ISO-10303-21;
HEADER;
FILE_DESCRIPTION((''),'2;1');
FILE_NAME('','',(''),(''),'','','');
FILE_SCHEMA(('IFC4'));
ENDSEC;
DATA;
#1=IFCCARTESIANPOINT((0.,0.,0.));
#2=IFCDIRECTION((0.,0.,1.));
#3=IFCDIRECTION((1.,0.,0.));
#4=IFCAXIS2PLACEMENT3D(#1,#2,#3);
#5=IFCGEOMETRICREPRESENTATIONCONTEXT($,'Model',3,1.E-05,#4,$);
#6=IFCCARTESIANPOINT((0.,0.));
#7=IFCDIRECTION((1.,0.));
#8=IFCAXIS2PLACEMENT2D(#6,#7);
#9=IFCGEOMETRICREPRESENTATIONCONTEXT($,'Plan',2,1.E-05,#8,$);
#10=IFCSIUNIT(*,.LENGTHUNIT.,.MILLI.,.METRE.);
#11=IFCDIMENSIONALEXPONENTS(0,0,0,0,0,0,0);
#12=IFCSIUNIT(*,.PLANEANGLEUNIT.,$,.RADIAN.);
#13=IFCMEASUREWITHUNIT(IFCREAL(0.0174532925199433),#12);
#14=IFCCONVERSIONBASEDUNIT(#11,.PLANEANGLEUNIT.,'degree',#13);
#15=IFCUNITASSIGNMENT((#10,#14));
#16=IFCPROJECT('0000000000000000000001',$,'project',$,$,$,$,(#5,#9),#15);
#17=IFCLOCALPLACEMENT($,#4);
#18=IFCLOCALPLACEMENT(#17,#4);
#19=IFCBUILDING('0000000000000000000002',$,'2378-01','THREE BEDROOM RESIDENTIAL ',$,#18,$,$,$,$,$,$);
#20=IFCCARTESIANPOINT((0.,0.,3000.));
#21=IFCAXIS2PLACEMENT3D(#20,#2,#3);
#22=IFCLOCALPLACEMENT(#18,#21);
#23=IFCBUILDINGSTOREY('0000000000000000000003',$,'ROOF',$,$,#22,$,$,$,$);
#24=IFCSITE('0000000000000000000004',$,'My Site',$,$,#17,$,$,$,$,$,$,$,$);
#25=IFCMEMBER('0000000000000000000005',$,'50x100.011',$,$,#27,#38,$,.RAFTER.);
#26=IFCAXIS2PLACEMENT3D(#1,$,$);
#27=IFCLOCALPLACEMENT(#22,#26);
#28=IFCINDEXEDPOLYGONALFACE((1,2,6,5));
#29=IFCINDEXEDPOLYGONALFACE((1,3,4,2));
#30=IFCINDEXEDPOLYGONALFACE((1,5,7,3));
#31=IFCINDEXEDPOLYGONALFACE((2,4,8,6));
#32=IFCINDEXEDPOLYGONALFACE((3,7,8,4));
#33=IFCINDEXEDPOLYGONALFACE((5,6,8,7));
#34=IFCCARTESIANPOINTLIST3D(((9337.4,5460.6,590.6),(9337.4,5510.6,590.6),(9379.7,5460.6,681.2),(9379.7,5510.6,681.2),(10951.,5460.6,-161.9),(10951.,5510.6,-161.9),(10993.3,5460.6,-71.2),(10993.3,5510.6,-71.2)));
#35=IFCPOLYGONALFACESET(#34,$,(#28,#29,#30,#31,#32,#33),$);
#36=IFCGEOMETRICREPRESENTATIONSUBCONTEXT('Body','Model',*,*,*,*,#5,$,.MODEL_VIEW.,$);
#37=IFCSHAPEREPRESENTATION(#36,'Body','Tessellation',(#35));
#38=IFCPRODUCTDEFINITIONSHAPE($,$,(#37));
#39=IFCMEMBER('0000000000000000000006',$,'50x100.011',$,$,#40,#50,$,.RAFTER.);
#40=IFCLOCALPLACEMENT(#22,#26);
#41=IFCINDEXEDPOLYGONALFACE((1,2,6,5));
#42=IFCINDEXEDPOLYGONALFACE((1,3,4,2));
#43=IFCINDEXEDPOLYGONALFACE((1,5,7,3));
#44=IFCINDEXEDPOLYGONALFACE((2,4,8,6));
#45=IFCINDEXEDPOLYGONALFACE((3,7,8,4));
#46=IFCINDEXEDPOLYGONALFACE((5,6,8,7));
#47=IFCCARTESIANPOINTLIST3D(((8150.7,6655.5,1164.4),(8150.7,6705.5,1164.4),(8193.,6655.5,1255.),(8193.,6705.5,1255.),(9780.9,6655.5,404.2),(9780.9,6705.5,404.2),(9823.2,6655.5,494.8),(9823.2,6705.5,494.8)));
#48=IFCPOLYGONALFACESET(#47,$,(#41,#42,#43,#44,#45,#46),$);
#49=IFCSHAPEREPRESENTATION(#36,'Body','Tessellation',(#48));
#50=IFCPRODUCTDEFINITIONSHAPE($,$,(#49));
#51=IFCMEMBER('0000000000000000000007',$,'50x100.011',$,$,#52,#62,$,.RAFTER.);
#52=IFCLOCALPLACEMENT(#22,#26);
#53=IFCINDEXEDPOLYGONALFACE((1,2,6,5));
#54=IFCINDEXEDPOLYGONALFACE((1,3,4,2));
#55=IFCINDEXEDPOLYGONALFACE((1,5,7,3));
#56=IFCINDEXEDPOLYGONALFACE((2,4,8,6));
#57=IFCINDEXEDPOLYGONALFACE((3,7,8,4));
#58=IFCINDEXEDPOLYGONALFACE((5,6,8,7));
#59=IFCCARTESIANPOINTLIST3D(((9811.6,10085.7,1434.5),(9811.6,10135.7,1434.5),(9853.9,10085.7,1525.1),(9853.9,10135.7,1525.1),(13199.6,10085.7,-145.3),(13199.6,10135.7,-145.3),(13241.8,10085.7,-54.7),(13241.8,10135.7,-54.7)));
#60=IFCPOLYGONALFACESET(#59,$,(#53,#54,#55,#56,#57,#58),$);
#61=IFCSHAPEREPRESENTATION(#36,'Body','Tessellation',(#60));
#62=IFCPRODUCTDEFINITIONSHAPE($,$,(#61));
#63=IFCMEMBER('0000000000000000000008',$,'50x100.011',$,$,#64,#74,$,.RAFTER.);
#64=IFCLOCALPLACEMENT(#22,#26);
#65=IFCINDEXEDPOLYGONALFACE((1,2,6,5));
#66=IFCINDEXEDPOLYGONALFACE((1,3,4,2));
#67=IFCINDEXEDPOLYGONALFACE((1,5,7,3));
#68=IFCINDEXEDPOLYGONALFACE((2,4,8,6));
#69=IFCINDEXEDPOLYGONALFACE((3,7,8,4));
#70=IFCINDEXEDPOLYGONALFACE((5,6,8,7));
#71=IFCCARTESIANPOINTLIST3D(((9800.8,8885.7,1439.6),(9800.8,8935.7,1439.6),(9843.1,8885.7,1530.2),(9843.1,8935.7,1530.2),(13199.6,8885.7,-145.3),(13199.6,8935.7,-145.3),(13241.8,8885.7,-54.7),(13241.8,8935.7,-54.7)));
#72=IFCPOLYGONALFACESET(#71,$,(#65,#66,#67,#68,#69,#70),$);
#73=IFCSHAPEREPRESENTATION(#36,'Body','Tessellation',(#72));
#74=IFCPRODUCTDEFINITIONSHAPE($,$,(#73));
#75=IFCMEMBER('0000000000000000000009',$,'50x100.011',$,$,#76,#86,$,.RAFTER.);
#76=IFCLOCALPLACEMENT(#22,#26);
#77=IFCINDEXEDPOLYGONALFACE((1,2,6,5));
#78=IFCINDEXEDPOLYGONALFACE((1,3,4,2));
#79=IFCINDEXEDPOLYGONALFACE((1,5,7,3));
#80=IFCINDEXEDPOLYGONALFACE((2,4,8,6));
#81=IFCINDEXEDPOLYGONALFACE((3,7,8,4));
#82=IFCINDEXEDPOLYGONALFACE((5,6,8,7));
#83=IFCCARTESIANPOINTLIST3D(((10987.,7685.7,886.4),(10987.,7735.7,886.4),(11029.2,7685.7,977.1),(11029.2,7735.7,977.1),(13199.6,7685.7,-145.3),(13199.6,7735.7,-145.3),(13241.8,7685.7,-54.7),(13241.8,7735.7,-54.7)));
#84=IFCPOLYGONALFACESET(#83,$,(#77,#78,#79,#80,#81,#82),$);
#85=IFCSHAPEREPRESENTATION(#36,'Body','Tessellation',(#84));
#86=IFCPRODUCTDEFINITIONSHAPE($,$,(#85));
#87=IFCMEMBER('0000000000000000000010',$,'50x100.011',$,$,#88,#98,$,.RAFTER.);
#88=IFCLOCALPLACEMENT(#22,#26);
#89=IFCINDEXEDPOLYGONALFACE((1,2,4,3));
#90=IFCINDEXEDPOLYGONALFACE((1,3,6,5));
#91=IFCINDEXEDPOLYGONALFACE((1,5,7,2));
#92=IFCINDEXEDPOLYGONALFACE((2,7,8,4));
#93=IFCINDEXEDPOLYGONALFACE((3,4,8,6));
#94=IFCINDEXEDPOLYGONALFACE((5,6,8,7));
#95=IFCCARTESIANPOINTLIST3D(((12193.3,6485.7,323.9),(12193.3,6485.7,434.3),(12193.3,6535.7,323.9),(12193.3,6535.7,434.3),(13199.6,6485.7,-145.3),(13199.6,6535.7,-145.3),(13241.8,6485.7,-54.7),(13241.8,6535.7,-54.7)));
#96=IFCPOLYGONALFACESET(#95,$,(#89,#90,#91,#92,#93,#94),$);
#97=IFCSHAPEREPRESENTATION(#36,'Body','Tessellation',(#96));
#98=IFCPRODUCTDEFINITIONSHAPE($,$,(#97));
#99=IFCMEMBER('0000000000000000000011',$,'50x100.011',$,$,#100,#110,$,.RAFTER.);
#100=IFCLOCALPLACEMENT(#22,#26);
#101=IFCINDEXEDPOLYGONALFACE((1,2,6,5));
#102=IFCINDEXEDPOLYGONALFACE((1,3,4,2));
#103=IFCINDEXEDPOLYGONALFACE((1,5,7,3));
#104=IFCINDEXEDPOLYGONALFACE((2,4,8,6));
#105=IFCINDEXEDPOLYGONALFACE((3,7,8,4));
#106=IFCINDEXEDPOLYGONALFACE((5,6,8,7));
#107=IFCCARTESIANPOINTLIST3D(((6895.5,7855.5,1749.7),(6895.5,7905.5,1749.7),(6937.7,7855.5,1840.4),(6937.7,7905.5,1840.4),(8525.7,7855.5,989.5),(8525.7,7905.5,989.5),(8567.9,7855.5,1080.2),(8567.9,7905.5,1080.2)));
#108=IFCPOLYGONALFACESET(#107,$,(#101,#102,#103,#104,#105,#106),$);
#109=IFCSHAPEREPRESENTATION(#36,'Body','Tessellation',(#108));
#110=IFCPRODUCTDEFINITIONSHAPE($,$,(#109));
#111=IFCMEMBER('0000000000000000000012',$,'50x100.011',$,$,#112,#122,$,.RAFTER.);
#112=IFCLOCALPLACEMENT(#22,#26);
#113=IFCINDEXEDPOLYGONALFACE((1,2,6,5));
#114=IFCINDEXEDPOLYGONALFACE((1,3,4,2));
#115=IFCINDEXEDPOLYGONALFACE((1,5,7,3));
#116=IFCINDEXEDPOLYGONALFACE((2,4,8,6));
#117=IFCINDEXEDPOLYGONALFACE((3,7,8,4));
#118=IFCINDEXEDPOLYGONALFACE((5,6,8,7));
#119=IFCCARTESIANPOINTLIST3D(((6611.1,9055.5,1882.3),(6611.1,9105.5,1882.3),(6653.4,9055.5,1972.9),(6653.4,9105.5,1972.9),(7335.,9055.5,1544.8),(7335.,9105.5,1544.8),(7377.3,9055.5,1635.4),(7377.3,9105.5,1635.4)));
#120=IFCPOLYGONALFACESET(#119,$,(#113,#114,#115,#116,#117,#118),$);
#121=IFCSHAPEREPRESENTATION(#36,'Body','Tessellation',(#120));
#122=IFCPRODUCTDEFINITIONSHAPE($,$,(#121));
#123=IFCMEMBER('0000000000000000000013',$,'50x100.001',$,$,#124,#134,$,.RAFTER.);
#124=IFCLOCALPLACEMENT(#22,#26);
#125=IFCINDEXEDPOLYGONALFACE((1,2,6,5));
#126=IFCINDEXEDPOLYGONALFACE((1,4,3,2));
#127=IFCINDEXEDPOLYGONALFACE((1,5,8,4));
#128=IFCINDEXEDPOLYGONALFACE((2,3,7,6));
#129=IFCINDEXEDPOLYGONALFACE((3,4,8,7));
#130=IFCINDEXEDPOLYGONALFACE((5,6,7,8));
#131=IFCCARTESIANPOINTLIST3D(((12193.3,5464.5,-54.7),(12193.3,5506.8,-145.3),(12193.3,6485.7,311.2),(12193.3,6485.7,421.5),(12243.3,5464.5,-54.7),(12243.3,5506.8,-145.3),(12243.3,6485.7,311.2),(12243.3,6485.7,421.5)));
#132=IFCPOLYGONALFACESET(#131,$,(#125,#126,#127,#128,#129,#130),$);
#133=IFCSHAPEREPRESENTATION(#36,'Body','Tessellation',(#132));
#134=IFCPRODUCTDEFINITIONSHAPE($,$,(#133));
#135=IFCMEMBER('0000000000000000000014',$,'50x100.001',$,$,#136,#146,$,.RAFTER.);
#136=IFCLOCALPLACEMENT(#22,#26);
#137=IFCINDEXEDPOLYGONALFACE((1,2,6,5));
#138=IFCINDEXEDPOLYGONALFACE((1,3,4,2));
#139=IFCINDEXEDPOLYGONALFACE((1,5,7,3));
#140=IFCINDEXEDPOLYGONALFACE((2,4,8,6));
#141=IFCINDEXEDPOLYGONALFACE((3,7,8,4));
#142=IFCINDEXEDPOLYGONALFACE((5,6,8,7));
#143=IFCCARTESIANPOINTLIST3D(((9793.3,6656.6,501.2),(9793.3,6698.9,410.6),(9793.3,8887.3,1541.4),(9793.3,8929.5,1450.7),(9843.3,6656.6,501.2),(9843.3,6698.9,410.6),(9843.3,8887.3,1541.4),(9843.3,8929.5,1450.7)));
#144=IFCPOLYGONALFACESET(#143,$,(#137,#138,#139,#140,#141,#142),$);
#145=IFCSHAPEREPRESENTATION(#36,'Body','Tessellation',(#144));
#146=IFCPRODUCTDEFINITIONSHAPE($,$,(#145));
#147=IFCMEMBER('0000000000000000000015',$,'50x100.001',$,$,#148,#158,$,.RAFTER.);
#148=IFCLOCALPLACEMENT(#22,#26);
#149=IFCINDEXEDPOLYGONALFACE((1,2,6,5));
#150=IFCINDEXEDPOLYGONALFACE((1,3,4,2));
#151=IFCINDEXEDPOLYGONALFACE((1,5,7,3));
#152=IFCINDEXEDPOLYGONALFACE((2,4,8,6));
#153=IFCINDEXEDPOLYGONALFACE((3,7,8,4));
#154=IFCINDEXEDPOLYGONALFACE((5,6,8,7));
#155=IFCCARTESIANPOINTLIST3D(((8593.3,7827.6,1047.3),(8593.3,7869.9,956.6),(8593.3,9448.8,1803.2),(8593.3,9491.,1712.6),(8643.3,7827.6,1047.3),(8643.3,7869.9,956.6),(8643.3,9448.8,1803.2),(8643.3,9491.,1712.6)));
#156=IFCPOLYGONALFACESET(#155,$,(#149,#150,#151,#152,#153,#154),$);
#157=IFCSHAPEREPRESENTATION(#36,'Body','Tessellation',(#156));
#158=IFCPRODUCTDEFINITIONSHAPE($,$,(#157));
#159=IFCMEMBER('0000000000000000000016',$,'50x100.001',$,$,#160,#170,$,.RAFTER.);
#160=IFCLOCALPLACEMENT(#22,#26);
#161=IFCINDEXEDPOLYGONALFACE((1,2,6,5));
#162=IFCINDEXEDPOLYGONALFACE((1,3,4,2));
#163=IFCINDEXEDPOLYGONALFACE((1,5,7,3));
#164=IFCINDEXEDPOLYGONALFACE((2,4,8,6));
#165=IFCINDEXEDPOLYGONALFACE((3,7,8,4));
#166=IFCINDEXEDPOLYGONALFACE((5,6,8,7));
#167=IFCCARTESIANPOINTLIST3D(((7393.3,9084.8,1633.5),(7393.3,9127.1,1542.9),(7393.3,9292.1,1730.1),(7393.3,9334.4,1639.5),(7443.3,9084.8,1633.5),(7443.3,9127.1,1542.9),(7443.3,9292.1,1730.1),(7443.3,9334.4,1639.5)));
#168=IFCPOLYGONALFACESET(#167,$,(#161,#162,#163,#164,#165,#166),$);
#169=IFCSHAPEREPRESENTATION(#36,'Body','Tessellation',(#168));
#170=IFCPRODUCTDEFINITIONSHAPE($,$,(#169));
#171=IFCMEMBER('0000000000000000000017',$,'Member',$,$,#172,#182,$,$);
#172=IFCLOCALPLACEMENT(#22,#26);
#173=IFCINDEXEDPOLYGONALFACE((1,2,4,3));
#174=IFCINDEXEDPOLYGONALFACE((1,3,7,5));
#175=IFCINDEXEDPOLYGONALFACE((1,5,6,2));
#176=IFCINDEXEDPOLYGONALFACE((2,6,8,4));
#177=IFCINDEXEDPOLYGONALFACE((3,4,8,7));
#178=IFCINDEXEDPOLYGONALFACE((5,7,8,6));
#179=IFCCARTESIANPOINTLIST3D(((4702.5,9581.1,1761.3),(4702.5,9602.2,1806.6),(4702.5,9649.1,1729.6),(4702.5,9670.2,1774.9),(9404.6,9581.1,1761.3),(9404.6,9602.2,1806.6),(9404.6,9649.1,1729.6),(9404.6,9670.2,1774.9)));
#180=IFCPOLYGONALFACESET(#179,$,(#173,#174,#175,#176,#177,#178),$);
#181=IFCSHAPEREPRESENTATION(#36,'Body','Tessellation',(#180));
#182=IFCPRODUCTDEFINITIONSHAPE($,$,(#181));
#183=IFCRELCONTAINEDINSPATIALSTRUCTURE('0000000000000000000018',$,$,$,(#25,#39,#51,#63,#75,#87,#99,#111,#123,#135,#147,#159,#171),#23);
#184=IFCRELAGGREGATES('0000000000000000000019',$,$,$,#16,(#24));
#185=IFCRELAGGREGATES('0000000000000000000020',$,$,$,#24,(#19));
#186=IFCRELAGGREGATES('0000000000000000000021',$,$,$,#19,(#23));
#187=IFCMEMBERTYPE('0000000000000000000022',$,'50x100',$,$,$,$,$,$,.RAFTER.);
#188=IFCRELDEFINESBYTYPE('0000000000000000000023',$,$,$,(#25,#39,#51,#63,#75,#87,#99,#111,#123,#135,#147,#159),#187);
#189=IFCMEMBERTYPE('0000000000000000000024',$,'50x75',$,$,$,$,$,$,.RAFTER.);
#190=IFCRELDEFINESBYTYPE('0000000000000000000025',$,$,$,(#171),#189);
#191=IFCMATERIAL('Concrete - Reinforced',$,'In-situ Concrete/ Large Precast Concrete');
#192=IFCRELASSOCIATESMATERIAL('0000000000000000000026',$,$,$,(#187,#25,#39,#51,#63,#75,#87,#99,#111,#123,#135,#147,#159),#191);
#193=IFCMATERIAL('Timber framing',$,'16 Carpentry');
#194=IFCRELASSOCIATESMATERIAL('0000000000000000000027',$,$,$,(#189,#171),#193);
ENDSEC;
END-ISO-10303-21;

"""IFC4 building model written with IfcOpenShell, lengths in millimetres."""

from ifc_helpers import new_model, entity, si_unit, converted_unit, frame, origin_with_axes, origin_2d_with_axis, place, context, subcontext, project, spatial, rectangle, extrude, clip, halfspace, material, material_profile, profile_set, profile_usage, type_object, element, save


model = new_model("IFC4")

# Units and contexts
model_context = context("Model", 3, precision=1e-05, world=origin_with_axes())
plan_context = context("Plan", 2, precision=1e-05, world=origin_2d_with_axis())
body_context = subcontext(model_context, "Body", "Model", "MODEL_VIEW")
ifc_project = project(units=[si_unit("LENGTHUNIT", "METRE", prefix="MILLI"), converted_unit("PLANEANGLEUNIT", "degree", entity("IfcReal", 0.0174532925199433), si_unit("PLANEANGLEUNIT", "RADIAN"), dimensions=[0, 0, 0, 0, 0, 0, 0])], contexts=[model_context, plan_context])

# Site, building, storey
site_placement = place(None, origin_with_axes())
site = spatial("IfcSite", under=ifc_project, at=site_placement, Name="My Site")
building_placement = place(site_placement, origin_with_axes())
building = spatial("IfcBuilding", under=site, at=building_placement, Name="2378-01", Description="THREE BEDROOM RESIDENTIAL ")
storey_placement = place(building_placement, frame((0.0, 0.0, 3000.0), z_axis=(0.0, 0.0, 1.0), x_axis=(1.0, 0.0, 0.0)))
storey = spatial("IfcBuildingStorey", under=building, at=storey_placement, Name="ROOF")

# Members
ifc_material_1 = material(Name="Concrete - Reinforced", Category="In-situ Concrete/ Large Precast Concrete")
ifc_material_profile_1 = material_profile(ifc_material_1, rectangle(XDim=50.0, YDim=100.0), Name="Core Layer", Category="LoadBearing", Priority=1)
ifc_profile_set_1 = profile_set([ifc_material_profile_1], Name="wood")
ifc_profile_usage_1 = profile_usage(ifc_profile_set_1, cardinal=5)
member_type_1 = type_object("IfcMemberType", Name="50x100", PredefinedType="RAFTER", material=ifc_profile_set_1)
member_1_placement = place(storey_placement, frame((10972.1, 5485.6, -116.6), z_axis=(-0.906308, 0.0, 0.422618), x_axis=(0.0, -1.0, 0.0)))
element("IfcMember", 1, at=member_1_placement, inside=storey, type_object=member_type_1, material=ifc_profile_usage_1, Name="50x100.011", PredefinedType="RAFTER", context=body_context, shape_type="SweptSolid", body=[
    extrude(rectangle(XDim=50.0, YDim=100.0), origin_with_axes(), (0.0, 0.0, 1.0), 1780.4),
])
ifc_profile_usage_2 = profile_usage(ifc_profile_set_1, cardinal=5)
member_2_placement = place(storey_placement, frame((9802.1, 6680.5, 449.5), z_axis=(-0.906308, 0.0, 0.422618), x_axis=(0.0, -1.0, 0.0)))
element("IfcMember", 2, at=member_2_placement, inside=storey, type_object=member_type_1, material=ifc_profile_usage_2, Name="50x100.011", PredefinedType="RAFTER", context=body_context, shape_type="SweptSolid", body=[
    extrude(rectangle(XDim=50.0, YDim=100.0), origin_with_axes(), (0.0, 0.0, 1.0), 1798.8),
])
ifc_profile_usage_3 = profile_usage(ifc_profile_set_1, cardinal=5)
member_3_placement = place(storey_placement, frame((13220.7, 10110.7, -100.0), z_axis=(-0.906308, 0.0, 0.422618), x_axis=(0.0, -1.0, 0.0)))
element("IfcMember", 3, at=member_3_placement, inside=storey, type_object=member_type_1, material=ifc_profile_usage_3, Name="50x100.011", PredefinedType="RAFTER", context=body_context, shape_type="SweptSolid", body=[
    extrude(rectangle(XDim=50.0, YDim=100.0), origin_with_axes(), (0.0, 0.0, 1.0), 3738.2),
])
ifc_profile_usage_4 = profile_usage(ifc_profile_set_1, cardinal=5)
member_4_placement = place(storey_placement, frame((13220.7, 8910.7, -100.0), z_axis=(-0.906308, 0.0, 0.422618), x_axis=(0.0, -1.0, 0.0)))
element("IfcMember", 4, at=member_4_placement, inside=storey, type_object=member_type_1, material=ifc_profile_usage_4, Name="50x100.011", PredefinedType="RAFTER", context=body_context, shape_type="SweptSolid", body=[
    extrude(rectangle(XDim=50.0, YDim=100.0), origin_with_axes(), (0.0, 0.0, 1.0), 3750.1),
])
ifc_profile_usage_5 = profile_usage(ifc_profile_set_1, cardinal=5)
member_5_placement = place(storey_placement, frame((13220.7, 7710.7, -100.0), z_axis=(-0.906308, 0.0, 0.422618), x_axis=(0.0, -1.0, 0.0)))
element("IfcMember", 5, at=member_5_placement, inside=storey, type_object=member_type_1, material=ifc_profile_usage_5, Name="50x100.011", PredefinedType="RAFTER", context=body_context, shape_type="SweptSolid", body=[
    extrude(rectangle(XDim=50.0, YDim=100.0), origin_with_axes(), (0.0, 0.0, 1.0), 2441.3),
])
ifc_profile_usage_6 = profile_usage(ifc_profile_set_1, cardinal=5)
member_6_placement = place(storey_placement, frame((13220.7, 6510.7, -100.0), z_axis=(-0.906308, 0.0, 0.422618), x_axis=(0.0, -1.0, 0.0)))
element("IfcMember", 6, at=member_6_placement, inside=storey, type_object=member_type_1, material=ifc_profile_usage_6, Name="50x100.011", PredefinedType="RAFTER", context=body_context, shape_type="Clipping", body=[
    clip(extrude(rectangle(XDim=50.0, YDim=100.0), origin_with_axes(), (0.0, 0.0, 1.0), 1233.6), halfspace(frame((1025.1, -429.6, 933.3), z_axis=(0.0, -0.422618, 0.906308), x_axis=(-1.0, -0.000001, 0.0)), False)),
])
ifc_profile_usage_7 = profile_usage(ifc_profile_set_1, cardinal=5)
member_7_placement = place(storey_placement, frame((8546.8, 7880.5, 1034.9), z_axis=(-0.906308, 0.0, 0.422618), x_axis=(0.0, -1.0, 0.0)))
element("IfcMember", 7, at=member_7_placement, inside=storey, type_object=member_type_1, material=ifc_profile_usage_7, Name="50x100.011", PredefinedType="RAFTER", context=body_context, shape_type="SweptSolid", body=[
    extrude(rectangle(XDim=50.0, YDim=100.0), origin_with_axes(), (0.0, 0.0, 1.0), 1798.8),
])
ifc_profile_usage_8 = profile_usage(ifc_profile_set_1, cardinal=5)
member_8_placement = place(storey_placement, frame((7356.2, 9080.5, 1590.1), z_axis=(-0.906308, 0.0, 0.422618), x_axis=(0.0, -1.0, 0.0)))
element("IfcMember", 8, at=member_8_placement, inside=storey, type_object=member_type_1, material=ifc_profile_usage_8, Name="50x100.011", PredefinedType="RAFTER", context=body_context, shape_type="SweptSolid", body=[
    extrude(rectangle(XDim=50.0, YDim=100.0), origin_with_axes(), (0.0, 0.0, 1.0), 798.8),
])
ifc_profile_usage_9 = profile_usage(ifc_profile_set_1)
member_9_placement = place(storey_placement, frame((12218.3, 5485.6, -100.0), z_axis=(0.0, 0.906308, 0.422618), x_axis=(-1.0, 0.0, 0.0)))
element("IfcMember", 9, at=member_9_placement, inside=storey, type_object=member_type_1, material=ifc_profile_usage_9, Name="50x100.001", PredefinedType="RAFTER", context=body_context, shape_type="Clipping", body=[
    clip(extrude(rectangle(XDim=50.0, YDim=100.0), origin_with_axes(), (0.0, 0.0, 1.0), 1203.5), halfspace(frame((-1002.4, -427.2, 904.2), z_axis=(0.0, -0.422618, 0.906308), x_axis=(-1.0, 0.000001, 0.0)), False)),
])
ifc_profile_usage_10 = profile_usage(ifc_profile_set_1)
member_10_placement = place(storey_placement, frame((9818.3, 6677.7, 455.9), z_axis=(0.0, 0.906308, 0.422618), x_axis=(-1.0, 0.0, 0.0)))
element("IfcMember", 10, at=member_10_placement, inside=storey, type_object=member_type_1, material=ifc_profile_usage_10, Name="50x100.001", PredefinedType="RAFTER", context=body_context, shape_type="SweptSolid", body=[
    extrude(rectangle(XDim=50.0, YDim=100.0), origin_with_axes(), (0.0, 0.0, 1.0), 2461.3),
])
ifc_profile_usage_11 = profile_usage(ifc_profile_set_1)
member_11_placement = place(storey_placement, frame((8618.3, 7848.8, 1001.9), z_axis=(0.0, 0.906308, 0.422618), x_axis=(-1.0, 0.0, 0.0)))
element("IfcMember", 11, at=member_11_placement, inside=storey, type_object=member_type_1, material=ifc_profile_usage_11, Name="50x100.001", PredefinedType="RAFTER", context=body_context, shape_type="SweptSolid", body=[
    extrude(rectangle(XDim=50.0, YDim=100.0), origin_with_axes(), (0.0, 0.0, 1.0), 1788.7),
])
ifc_profile_usage_12 = profile_usage(ifc_profile_set_1)
member_12_placement = place(storey_placement, frame((7418.3, 9105.9, 1588.2), z_axis=(0.0, 0.906308, 0.422618), x_axis=(-1.0, 0.0, 0.0)))
element("IfcMember", 12, at=member_12_placement, inside=storey, type_object=member_type_1, material=ifc_profile_usage_12, Name="50x100.001", PredefinedType="RAFTER", context=body_context, shape_type="SweptSolid", body=[
    extrude(rectangle(XDim=50.0, YDim=100.0), origin_with_axes(), (0.0, 0.0, 1.0), 228.7),
])
ifc_material_2 = material(Name="Timber framing", Category="16 Carpentry")
ifc_material_profile_2 = material_profile(ifc_material_2, rectangle(XDim=50.0, YDim=75.0), Name="Lumber2", Category="Substrate", Priority=2)
ifc_profile_set_2 = profile_set([ifc_material_profile_2])
ifc_profile_usage_13 = profile_usage(ifc_profile_set_2, cardinal=5)
member_type_2 = type_object("IfcMemberType", Name="50x75", PredefinedType="RAFTER", material=ifc_profile_set_2)
member_13_placement = place(storey_placement, frame((9404.6, 9625.7, 1768.1), z_axis=(-1.0, 0.0, 0.0), x_axis=(0.0, -0.422618, -0.906308)))
element("IfcMember", 13, at=member_13_placement, inside=storey, type_object=member_type_2, material=ifc_profile_usage_13, Name="Member", context=body_context, shape_type="SweptSolid", body=[
    extrude(rectangle(XDim=50.0, YDim=75.0), origin_with_axes(), (0.0, 0.0, 1.0), 4702.1),
])

save(model, "model.ifc")
